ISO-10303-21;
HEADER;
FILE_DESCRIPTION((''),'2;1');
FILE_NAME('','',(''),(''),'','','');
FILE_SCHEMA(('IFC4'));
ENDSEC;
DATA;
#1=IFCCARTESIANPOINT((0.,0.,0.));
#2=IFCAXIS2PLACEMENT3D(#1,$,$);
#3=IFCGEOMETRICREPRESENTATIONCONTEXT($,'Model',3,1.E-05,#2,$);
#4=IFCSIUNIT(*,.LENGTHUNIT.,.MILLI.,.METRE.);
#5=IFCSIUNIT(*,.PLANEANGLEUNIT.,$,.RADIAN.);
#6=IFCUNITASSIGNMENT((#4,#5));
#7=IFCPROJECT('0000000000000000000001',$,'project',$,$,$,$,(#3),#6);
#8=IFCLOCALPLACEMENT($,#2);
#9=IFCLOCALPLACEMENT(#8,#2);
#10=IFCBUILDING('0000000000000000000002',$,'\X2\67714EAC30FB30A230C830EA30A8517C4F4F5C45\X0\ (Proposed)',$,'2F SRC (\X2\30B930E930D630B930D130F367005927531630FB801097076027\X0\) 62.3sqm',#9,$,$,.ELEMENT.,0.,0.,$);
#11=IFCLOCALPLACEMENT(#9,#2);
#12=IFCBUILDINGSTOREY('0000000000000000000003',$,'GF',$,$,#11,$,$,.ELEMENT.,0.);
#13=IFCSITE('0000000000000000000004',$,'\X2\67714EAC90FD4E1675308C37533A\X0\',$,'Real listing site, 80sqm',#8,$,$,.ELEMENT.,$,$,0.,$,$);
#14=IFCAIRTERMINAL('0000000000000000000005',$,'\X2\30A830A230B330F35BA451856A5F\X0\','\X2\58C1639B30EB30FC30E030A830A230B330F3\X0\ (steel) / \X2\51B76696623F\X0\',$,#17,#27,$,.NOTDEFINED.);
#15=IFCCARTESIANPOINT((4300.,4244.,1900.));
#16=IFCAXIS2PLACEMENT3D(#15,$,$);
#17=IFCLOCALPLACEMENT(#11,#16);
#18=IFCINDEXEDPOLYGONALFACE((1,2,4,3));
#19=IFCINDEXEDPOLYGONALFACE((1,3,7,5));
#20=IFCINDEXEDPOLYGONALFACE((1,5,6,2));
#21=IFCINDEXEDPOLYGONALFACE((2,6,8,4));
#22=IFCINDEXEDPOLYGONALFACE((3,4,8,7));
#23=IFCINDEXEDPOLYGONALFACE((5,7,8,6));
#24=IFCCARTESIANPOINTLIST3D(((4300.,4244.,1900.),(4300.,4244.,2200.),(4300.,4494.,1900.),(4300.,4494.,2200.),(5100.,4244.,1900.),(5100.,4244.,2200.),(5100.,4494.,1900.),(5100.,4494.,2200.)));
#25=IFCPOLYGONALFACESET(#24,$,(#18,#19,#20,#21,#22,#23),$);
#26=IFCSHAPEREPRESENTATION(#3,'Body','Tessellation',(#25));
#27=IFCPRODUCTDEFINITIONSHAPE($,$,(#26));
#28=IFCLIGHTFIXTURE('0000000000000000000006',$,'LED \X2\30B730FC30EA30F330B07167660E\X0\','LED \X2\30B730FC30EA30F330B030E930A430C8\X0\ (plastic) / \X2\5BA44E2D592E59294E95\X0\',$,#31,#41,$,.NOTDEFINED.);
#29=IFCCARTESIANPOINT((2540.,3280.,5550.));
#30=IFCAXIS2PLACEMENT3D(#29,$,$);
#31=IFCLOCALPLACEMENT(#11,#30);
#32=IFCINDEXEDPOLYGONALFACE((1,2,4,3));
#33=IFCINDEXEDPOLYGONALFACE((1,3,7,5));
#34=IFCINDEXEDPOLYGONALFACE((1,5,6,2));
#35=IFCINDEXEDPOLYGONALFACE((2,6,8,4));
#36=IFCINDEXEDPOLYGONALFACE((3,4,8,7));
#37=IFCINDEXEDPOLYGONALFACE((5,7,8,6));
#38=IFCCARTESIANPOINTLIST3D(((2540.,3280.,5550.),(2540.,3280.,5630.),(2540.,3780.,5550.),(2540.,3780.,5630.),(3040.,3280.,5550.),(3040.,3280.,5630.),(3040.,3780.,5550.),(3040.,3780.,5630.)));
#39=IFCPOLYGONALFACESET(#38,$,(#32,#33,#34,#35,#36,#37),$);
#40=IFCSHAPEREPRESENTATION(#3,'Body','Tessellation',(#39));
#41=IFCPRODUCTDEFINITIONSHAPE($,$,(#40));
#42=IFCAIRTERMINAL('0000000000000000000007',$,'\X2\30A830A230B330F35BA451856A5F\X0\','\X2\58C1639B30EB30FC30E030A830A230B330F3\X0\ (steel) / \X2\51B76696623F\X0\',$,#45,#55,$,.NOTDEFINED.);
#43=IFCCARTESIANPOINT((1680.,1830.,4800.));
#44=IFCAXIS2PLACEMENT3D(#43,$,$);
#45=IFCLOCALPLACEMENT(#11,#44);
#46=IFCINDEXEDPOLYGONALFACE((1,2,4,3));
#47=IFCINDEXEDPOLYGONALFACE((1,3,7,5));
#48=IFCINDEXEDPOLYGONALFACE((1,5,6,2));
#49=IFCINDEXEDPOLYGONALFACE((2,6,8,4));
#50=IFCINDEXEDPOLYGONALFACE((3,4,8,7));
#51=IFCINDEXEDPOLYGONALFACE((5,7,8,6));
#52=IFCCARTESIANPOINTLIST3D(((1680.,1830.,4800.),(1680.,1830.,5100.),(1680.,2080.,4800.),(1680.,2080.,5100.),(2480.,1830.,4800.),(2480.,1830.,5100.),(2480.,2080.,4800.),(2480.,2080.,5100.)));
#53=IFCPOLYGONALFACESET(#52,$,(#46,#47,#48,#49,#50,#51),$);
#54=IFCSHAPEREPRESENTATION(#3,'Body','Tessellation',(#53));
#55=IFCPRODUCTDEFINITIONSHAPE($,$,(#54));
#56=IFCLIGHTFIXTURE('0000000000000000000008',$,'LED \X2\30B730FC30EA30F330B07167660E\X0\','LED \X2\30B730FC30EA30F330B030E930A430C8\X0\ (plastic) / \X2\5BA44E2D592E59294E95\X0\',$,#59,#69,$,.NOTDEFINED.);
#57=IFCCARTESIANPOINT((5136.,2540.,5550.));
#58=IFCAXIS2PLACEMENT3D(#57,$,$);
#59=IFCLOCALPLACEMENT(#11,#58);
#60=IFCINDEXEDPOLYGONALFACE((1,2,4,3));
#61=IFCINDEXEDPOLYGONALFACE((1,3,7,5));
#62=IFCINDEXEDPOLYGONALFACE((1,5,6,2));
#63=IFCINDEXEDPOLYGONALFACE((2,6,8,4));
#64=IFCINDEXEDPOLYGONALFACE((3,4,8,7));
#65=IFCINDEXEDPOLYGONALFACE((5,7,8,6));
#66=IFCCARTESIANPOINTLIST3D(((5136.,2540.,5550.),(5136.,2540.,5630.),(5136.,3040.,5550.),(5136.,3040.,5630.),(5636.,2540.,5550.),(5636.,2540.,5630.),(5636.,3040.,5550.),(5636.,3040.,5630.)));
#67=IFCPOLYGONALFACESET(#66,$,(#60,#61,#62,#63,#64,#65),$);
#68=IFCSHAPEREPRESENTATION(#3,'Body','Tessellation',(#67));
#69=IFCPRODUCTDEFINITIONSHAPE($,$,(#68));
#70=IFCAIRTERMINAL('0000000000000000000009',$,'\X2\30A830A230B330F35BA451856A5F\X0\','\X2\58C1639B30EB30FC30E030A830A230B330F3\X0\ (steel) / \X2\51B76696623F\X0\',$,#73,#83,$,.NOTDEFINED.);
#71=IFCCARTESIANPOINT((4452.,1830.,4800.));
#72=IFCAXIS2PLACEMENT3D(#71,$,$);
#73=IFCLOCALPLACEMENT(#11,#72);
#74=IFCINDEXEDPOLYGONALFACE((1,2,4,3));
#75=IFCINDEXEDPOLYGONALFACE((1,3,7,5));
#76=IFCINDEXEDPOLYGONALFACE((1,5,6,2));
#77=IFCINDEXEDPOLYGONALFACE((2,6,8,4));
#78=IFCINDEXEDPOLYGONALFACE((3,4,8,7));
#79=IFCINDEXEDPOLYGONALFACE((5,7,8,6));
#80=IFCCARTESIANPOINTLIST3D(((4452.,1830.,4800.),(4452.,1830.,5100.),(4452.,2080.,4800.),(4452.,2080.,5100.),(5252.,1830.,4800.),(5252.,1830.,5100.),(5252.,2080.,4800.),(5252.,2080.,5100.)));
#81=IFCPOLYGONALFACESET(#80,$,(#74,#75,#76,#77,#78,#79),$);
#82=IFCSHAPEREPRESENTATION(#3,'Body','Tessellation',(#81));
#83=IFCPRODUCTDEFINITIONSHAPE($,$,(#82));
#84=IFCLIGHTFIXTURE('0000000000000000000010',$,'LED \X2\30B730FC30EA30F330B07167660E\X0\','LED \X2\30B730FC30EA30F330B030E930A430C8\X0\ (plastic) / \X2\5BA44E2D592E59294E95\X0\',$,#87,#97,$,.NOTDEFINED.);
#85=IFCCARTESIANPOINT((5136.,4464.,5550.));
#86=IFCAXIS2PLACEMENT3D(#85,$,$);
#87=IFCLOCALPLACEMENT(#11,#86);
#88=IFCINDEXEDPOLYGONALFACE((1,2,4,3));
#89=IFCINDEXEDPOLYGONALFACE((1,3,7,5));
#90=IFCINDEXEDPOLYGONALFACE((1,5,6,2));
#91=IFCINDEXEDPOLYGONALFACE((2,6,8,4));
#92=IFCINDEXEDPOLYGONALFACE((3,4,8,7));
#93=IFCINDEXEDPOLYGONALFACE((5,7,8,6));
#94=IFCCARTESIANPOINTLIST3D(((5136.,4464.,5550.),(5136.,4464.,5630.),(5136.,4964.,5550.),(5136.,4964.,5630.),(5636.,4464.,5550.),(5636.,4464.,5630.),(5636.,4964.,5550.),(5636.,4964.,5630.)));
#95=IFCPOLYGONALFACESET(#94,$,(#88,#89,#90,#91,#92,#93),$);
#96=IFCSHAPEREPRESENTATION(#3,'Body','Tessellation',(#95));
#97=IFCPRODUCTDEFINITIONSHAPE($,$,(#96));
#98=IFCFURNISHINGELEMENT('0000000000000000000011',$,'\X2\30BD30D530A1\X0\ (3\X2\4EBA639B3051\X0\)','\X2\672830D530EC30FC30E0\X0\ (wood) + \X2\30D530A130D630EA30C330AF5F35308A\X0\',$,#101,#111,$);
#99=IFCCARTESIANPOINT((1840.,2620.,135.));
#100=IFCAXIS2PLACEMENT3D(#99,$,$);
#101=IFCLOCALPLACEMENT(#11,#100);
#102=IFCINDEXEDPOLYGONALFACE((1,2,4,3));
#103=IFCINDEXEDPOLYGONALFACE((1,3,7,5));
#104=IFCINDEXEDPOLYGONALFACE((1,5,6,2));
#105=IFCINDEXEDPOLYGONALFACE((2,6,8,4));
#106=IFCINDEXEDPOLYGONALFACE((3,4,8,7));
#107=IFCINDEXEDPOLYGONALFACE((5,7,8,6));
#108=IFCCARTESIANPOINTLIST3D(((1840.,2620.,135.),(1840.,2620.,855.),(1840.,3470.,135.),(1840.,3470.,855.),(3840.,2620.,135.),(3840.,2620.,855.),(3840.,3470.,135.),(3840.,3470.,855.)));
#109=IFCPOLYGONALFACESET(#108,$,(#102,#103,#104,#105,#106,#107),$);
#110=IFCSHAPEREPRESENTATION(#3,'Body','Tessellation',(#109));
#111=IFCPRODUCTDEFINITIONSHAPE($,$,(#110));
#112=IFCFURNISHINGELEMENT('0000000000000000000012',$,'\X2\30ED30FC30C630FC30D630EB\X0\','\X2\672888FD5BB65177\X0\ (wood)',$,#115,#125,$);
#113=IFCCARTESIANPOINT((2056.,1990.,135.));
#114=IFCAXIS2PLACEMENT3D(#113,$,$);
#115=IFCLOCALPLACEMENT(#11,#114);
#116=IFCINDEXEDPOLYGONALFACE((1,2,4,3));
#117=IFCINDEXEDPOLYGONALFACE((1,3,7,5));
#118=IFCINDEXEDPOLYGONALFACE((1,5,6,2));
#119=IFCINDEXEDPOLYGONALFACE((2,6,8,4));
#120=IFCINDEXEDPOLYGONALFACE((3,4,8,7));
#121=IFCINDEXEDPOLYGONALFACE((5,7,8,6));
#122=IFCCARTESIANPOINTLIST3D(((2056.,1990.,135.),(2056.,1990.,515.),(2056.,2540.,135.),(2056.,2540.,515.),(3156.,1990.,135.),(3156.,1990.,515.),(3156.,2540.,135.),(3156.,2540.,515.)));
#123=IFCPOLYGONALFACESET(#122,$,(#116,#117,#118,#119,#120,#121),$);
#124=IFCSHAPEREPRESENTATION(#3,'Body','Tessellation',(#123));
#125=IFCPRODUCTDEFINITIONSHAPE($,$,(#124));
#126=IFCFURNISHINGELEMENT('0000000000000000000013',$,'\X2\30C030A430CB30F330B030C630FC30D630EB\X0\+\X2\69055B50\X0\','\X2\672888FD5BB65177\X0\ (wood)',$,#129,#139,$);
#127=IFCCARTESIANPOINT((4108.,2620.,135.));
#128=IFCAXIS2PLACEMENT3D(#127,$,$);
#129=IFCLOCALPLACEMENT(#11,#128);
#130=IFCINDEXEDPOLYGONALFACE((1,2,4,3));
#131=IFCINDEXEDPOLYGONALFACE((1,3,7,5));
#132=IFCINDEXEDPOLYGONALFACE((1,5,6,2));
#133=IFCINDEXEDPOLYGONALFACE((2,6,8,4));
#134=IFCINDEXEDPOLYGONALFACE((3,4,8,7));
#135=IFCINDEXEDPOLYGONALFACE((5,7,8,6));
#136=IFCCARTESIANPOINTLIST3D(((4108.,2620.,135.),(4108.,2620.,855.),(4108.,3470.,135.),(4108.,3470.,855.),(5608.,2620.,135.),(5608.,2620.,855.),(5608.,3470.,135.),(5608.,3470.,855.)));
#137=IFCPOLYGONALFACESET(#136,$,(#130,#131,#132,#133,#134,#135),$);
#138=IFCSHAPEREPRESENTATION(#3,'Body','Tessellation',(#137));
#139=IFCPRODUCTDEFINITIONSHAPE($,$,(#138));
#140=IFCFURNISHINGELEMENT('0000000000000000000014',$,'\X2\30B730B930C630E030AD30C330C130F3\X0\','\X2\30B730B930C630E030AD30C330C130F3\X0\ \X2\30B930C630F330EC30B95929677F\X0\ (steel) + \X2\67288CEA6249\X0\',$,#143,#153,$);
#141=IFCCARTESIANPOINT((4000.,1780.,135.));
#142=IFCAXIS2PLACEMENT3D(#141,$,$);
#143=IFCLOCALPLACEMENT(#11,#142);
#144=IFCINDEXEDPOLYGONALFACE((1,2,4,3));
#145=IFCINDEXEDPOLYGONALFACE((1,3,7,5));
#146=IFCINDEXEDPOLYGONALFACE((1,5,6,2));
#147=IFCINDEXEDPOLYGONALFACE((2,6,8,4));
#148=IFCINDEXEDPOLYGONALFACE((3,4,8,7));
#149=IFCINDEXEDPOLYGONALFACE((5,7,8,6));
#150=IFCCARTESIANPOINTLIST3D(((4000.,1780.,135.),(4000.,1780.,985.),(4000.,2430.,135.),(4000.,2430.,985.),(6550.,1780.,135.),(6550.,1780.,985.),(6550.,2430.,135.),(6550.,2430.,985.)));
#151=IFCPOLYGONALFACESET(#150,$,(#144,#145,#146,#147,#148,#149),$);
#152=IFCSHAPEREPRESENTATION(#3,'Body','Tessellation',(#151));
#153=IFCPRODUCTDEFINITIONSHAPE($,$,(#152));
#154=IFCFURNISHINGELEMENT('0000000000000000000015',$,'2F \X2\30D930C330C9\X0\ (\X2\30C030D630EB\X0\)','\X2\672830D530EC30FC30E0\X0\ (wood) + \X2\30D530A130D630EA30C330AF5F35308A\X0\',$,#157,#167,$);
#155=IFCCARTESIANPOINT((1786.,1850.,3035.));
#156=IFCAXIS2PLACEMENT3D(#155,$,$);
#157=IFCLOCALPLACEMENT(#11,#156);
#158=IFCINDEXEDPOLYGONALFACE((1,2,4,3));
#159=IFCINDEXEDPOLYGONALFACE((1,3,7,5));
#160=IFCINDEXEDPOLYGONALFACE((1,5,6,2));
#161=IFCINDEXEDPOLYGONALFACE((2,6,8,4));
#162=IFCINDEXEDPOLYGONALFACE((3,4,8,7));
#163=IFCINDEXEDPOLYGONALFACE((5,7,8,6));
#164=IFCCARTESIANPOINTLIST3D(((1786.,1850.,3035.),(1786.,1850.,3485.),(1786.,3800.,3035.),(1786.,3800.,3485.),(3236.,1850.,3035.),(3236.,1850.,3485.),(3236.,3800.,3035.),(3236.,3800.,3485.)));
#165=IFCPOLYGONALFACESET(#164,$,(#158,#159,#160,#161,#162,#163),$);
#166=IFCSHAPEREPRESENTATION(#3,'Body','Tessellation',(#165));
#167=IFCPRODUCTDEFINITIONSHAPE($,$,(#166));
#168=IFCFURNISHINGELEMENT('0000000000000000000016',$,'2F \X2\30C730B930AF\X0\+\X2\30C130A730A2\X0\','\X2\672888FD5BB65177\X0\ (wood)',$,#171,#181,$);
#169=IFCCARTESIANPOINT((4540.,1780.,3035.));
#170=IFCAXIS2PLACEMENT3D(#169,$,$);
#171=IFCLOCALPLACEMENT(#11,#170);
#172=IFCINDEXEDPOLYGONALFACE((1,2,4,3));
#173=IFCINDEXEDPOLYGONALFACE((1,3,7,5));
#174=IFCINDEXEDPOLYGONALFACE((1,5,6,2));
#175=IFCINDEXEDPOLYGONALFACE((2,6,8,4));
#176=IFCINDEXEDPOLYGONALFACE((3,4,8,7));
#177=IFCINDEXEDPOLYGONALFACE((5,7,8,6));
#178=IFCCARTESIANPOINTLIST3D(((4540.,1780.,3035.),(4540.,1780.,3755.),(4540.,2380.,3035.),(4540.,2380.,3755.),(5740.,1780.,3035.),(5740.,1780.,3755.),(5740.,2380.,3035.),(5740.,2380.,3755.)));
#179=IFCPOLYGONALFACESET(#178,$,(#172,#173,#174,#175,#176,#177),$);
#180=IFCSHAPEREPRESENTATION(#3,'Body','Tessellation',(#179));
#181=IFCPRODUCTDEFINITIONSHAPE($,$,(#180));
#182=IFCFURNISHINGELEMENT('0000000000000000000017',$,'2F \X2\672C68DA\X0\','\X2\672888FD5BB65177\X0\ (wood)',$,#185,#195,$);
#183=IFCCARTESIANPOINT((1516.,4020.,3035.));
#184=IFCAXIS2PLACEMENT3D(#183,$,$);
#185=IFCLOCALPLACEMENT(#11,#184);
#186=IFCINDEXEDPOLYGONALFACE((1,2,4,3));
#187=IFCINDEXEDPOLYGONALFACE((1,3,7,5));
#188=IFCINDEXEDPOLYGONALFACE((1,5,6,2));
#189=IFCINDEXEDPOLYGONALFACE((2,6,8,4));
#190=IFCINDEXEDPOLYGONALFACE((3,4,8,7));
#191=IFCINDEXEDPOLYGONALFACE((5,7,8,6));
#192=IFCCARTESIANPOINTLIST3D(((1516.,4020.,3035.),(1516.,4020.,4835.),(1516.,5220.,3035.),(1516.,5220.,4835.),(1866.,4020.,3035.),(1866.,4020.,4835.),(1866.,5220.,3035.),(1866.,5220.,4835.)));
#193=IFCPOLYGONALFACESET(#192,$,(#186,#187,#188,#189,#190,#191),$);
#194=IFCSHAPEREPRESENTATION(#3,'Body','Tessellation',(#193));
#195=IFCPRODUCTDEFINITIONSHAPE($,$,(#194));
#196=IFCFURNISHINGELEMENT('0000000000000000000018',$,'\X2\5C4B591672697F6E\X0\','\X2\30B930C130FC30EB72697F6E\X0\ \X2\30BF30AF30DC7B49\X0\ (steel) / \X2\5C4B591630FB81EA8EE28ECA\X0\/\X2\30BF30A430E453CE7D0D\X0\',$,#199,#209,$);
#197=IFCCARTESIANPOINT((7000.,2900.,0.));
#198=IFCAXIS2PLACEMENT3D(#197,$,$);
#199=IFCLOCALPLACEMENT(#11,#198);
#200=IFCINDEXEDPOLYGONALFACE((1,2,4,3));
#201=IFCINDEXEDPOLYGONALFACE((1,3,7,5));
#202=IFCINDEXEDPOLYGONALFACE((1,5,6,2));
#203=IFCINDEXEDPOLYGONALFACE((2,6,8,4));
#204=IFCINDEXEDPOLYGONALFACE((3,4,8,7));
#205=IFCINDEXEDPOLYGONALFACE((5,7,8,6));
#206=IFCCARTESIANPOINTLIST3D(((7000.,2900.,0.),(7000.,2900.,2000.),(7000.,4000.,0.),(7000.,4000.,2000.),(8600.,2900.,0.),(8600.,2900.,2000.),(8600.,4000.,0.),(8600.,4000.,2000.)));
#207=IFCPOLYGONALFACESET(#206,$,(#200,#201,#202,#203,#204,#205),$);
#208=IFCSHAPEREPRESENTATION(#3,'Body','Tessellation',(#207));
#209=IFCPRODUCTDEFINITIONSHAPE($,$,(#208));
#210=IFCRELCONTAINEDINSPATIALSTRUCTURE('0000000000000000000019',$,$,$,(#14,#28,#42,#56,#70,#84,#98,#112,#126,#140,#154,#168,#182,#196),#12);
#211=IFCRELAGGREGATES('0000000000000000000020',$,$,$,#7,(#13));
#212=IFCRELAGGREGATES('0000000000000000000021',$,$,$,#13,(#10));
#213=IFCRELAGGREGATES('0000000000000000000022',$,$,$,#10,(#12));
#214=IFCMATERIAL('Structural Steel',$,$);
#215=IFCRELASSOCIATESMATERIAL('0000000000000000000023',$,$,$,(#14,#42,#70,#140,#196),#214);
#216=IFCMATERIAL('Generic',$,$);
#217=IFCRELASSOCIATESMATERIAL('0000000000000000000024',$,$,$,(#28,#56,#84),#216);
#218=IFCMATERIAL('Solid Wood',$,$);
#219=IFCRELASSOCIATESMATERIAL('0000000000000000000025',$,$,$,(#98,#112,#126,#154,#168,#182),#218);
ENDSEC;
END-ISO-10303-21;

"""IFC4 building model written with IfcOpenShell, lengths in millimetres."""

from ifc_helpers import new_model, si_unit, frame, frame_2d, origin, place, context, project, spatial, rectangle, extrude, material, element, save


model = new_model("IFC4")

# Units and contexts
model_context = context("Model", 3, precision=1e-05, world=origin())
ifc_project = project(units=[si_unit("LENGTHUNIT", "METRE", prefix="MILLI"), si_unit("PLANEANGLEUNIT", "RADIAN")], contexts=[model_context])

# Site, building, storey
site_placement = place(None, origin())
site = spatial("IfcSite", under=ifc_project, at=site_placement, Name="東京都世田谷区", ObjectType="Real listing site, 80sqm", CompositionType="ELEMENT", RefElevation=0.0)
building_placement = place(site_placement, origin())
building = spatial("IfcBuilding", under=site, at=building_placement, Name="東京・アトリエ兼住居 (Proposed)", ObjectType="2F SRC (スラブスパン最大化・耐震性) 62.3sqm", CompositionType="ELEMENT", ElevationOfRefHeight=0.0, ElevationOfTerrain=0.0)
storey_placement = place(building_placement, origin())
storey = spatial("IfcBuildingStorey", under=building, at=storey_placement, Name="GF", CompositionType="ELEMENT", Elevation=0.0)

# Shared definitions
ifc_material_1 = material(Name="Solid Wood")

# Shared definitions
ifc_material_2 = material(Name="Structural Steel")

# Shared definitions
ifc_material_3 = material(Name="Generic")

# Air terminal
air_terminal_1_placement = place(storey_placement, frame((4300.0, 4244.0, 1900.0)))
element("IfcAirTerminal", 1, at=air_terminal_1_placement, inside=storey, material=ifc_material_2, Name="エアコン室内機", Description="壁掛ルームエアコン (steel) / 冷暖房", PredefinedType="NOTDEFINED", context=model_context, shape_type="SweptSolid", body=[
    extrude(rectangle(XDim=800.0, YDim=250.0, at=frame_2d((400.0, 125.0))), frame((4300.0, 4244.0, 1900.0)), (0.0, 0.0, 1.0), 300.0),
])

# Light fixture
light_fixture_1_placement = place(storey_placement, frame((2540.0, 3280.0, 5550.0)))
element("IfcLightFixture", 2, at=light_fixture_1_placement, inside=storey, material=ifc_material_3, Name="LED シーリング照明", Description="LED シーリングライト (plastic) / 室中央天井", PredefinedType="NOTDEFINED", context=model_context, shape_type="SweptSolid", body=[
    extrude(rectangle(XDim=500.0, YDim=500.0, at=frame_2d((250.0, 250.0))), frame((2540.0, 3280.0, 5550.0)), (0.0, 0.0, 1.0), 80.0),
])

# Air terminal
air_terminal_2_placement = place(storey_placement, frame((1680.0, 1830.0, 4800.0)))
element("IfcAirTerminal", 3, at=air_terminal_2_placement, inside=storey, material=ifc_material_2, Name="エアコン室内機", Description="壁掛ルームエアコン (steel) / 冷暖房", PredefinedType="NOTDEFINED", context=model_context, shape_type="SweptSolid", body=[
    extrude(rectangle(XDim=800.0, YDim=250.0, at=frame_2d((400.0, 125.0))), frame((1680.0, 1830.0, 4800.0)), (0.0, 0.0, 1.0), 300.0),
])

# Light fixture
light_fixture_2_placement = place(storey_placement, frame((5136.0, 2540.0, 5550.0)))
element("IfcLightFixture", 4, at=light_fixture_2_placement, inside=storey, material=ifc_material_3, Name="LED シーリング照明", Description="LED シーリングライト (plastic) / 室中央天井", PredefinedType="NOTDEFINED", context=model_context, shape_type="SweptSolid", body=[
    extrude(rectangle(XDim=500.0, YDim=500.0, at=frame_2d((250.0, 250.0))), frame((5136.0, 2540.0, 5550.0)), (0.0, 0.0, 1.0), 80.0),
])

# Air terminal
air_terminal_3_placement = place(storey_placement, frame((4452.0, 1830.0, 4800.0)))
element("IfcAirTerminal", 5, at=air_terminal_3_placement, inside=storey, material=ifc_material_2, Name="エアコン室内機", Description="壁掛ルームエアコン (steel) / 冷暖房", PredefinedType="NOTDEFINED", context=model_context, shape_type="SweptSolid", body=[
    extrude(rectangle(XDim=800.0, YDim=250.0, at=frame_2d((400.0, 125.0))), frame((4452.0, 1830.0, 4800.0)), (0.0, 0.0, 1.0), 300.0),
])

# Light fixture
light_fixture_3_placement = place(storey_placement, frame((5136.0, 4464.0, 5550.0)))
element("IfcLightFixture", 6, at=light_fixture_3_placement, inside=storey, material=ifc_material_3, Name="LED シーリング照明", Description="LED シーリングライト (plastic) / 室中央天井", PredefinedType="NOTDEFINED", context=model_context, shape_type="SweptSolid", body=[
    extrude(rectangle(XDim=500.0, YDim=500.0, at=frame_2d((250.0, 250.0))), frame((5136.0, 4464.0, 5550.0)), (0.0, 0.0, 1.0), 80.0),
])

# Furnishing elements
furnishing_1_placement = place(storey_placement, frame((1840.0, 2620.0, 135.0)))
element("IfcFurnishingElement", 7, at=furnishing_1_placement, inside=storey, material=ifc_material_1, Name="ソファ (3人掛け)", Description="木フレーム (wood) + ファブリック張り", context=model_context, shape_type="SweptSolid", body=[
    extrude(rectangle(XDim=2000.0, YDim=850.0, at=frame_2d((1000.0, 425.0))), frame((1840.0, 2620.0, 135.0)), (0.0, 0.0, 1.0), 720.0),
])
furnishing_2_placement = place(storey_placement, frame((2056.0, 1990.0, 135.0)))
element("IfcFurnishingElement", 8, at=furnishing_2_placement, inside=storey, material=ifc_material_1, Name="ローテーブル", Description="木製家具 (wood)", context=model_context, shape_type="SweptSolid", body=[
    extrude(rectangle(XDim=1100.0, YDim=550.0, at=frame_2d((550.0, 275.0))), frame((2056.0, 1990.0, 135.0)), (0.0, 0.0, 1.0), 380.0),
])
furnishing_3_placement = place(storey_placement, frame((4108.0, 2620.0, 135.0)))
element("IfcFurnishingElement", 9, at=furnishing_3_placement, inside=storey, material=ifc_material_1, Name="ダイニングテーブル+椅子", Description="木製家具 (wood)", context=model_context, shape_type="SweptSolid", body=[
    extrude(rectangle(XDim=1500.0, YDim=850.0, at=frame_2d((750.0, 425.0))), frame((4108.0, 2620.0, 135.0)), (0.0, 0.0, 1.0), 720.0),
])
furnishing_4_placement = place(storey_placement, frame((4000.0, 1780.0, 135.0)))
element("IfcFurnishingElement", 10, at=furnishing_4_placement, inside=storey, material=ifc_material_2, Name="システムキッチン", Description="システムキッチン ステンレス天板 (steel) + 木質扉", context=model_context, shape_type="SweptSolid", body=[
    extrude(rectangle(XDim=2550.0, YDim=650.0, at=frame_2d((1275.0, 325.0))), frame((4000.0, 1780.0, 135.0)), (0.0, 0.0, 1.0), 850.0),
])
furnishing_5_placement = place(storey_placement, frame((1786.0, 1850.0, 3035.0)))
element("IfcFurnishingElement", 11, at=furnishing_5_placement, inside=storey, material=ifc_material_1, Name="2F ベッド (ダブル)", Description="木フレーム (wood) + ファブリック張り", context=model_context, shape_type="SweptSolid", body=[
    extrude(rectangle(XDim=1450.0, YDim=1950.0, at=frame_2d((725.0, 975.0))), frame((1786.0, 1850.0, 3035.0)), (0.0, 0.0, 1.0), 450.0),
])
furnishing_6_placement = place(storey_placement, frame((4540.0, 1780.0, 3035.0)))
element("IfcFurnishingElement", 12, at=furnishing_6_placement, inside=storey, material=ifc_material_1, Name="2F デスク+チェア", Description="木製家具 (wood)", context=model_context, shape_type="SweptSolid", body=[
    extrude(rectangle(XDim=1200.0, YDim=600.0, at=frame_2d((600.0, 300.0))), frame((4540.0, 1780.0, 3035.0)), (0.0, 0.0, 1.0), 720.0),
])
furnishing_7_placement = place(storey_placement, frame((1516.0, 4020.0, 3035.0)))
element("IfcFurnishingElement", 13, at=furnishing_7_placement, inside=storey, material=ifc_material_1, Name="2F 本棚", Description="木製家具 (wood)", context=model_context, shape_type="SweptSolid", body=[
    extrude(rectangle(XDim=350.0, YDim=1200.0, at=frame_2d((175.0, 600.0))), frame((1516.0, 4020.0, 3035.0)), (0.0, 0.0, 1.0), 1800.0),
])
furnishing_8_placement = place(storey_placement, frame((7000.0, 2900.0, 0.0)))
element("IfcFurnishingElement", 14, at=furnishing_8_placement, inside=storey, material=ifc_material_2, Name="屋外物置", Description="スチール物置 タクボ等 (steel) / 屋外・自転車/タイヤ収納", context=model_context, shape_type="SweptSolid", body=[
    extrude(rectangle(XDim=1600.0, YDim=1100.0, at=frame_2d((800.0, 550.0))), frame((7000.0, 2900.0, 0.0)), (0.0, 0.0, 1.0), 2000.0),
])

save(model, "model.ifc")
